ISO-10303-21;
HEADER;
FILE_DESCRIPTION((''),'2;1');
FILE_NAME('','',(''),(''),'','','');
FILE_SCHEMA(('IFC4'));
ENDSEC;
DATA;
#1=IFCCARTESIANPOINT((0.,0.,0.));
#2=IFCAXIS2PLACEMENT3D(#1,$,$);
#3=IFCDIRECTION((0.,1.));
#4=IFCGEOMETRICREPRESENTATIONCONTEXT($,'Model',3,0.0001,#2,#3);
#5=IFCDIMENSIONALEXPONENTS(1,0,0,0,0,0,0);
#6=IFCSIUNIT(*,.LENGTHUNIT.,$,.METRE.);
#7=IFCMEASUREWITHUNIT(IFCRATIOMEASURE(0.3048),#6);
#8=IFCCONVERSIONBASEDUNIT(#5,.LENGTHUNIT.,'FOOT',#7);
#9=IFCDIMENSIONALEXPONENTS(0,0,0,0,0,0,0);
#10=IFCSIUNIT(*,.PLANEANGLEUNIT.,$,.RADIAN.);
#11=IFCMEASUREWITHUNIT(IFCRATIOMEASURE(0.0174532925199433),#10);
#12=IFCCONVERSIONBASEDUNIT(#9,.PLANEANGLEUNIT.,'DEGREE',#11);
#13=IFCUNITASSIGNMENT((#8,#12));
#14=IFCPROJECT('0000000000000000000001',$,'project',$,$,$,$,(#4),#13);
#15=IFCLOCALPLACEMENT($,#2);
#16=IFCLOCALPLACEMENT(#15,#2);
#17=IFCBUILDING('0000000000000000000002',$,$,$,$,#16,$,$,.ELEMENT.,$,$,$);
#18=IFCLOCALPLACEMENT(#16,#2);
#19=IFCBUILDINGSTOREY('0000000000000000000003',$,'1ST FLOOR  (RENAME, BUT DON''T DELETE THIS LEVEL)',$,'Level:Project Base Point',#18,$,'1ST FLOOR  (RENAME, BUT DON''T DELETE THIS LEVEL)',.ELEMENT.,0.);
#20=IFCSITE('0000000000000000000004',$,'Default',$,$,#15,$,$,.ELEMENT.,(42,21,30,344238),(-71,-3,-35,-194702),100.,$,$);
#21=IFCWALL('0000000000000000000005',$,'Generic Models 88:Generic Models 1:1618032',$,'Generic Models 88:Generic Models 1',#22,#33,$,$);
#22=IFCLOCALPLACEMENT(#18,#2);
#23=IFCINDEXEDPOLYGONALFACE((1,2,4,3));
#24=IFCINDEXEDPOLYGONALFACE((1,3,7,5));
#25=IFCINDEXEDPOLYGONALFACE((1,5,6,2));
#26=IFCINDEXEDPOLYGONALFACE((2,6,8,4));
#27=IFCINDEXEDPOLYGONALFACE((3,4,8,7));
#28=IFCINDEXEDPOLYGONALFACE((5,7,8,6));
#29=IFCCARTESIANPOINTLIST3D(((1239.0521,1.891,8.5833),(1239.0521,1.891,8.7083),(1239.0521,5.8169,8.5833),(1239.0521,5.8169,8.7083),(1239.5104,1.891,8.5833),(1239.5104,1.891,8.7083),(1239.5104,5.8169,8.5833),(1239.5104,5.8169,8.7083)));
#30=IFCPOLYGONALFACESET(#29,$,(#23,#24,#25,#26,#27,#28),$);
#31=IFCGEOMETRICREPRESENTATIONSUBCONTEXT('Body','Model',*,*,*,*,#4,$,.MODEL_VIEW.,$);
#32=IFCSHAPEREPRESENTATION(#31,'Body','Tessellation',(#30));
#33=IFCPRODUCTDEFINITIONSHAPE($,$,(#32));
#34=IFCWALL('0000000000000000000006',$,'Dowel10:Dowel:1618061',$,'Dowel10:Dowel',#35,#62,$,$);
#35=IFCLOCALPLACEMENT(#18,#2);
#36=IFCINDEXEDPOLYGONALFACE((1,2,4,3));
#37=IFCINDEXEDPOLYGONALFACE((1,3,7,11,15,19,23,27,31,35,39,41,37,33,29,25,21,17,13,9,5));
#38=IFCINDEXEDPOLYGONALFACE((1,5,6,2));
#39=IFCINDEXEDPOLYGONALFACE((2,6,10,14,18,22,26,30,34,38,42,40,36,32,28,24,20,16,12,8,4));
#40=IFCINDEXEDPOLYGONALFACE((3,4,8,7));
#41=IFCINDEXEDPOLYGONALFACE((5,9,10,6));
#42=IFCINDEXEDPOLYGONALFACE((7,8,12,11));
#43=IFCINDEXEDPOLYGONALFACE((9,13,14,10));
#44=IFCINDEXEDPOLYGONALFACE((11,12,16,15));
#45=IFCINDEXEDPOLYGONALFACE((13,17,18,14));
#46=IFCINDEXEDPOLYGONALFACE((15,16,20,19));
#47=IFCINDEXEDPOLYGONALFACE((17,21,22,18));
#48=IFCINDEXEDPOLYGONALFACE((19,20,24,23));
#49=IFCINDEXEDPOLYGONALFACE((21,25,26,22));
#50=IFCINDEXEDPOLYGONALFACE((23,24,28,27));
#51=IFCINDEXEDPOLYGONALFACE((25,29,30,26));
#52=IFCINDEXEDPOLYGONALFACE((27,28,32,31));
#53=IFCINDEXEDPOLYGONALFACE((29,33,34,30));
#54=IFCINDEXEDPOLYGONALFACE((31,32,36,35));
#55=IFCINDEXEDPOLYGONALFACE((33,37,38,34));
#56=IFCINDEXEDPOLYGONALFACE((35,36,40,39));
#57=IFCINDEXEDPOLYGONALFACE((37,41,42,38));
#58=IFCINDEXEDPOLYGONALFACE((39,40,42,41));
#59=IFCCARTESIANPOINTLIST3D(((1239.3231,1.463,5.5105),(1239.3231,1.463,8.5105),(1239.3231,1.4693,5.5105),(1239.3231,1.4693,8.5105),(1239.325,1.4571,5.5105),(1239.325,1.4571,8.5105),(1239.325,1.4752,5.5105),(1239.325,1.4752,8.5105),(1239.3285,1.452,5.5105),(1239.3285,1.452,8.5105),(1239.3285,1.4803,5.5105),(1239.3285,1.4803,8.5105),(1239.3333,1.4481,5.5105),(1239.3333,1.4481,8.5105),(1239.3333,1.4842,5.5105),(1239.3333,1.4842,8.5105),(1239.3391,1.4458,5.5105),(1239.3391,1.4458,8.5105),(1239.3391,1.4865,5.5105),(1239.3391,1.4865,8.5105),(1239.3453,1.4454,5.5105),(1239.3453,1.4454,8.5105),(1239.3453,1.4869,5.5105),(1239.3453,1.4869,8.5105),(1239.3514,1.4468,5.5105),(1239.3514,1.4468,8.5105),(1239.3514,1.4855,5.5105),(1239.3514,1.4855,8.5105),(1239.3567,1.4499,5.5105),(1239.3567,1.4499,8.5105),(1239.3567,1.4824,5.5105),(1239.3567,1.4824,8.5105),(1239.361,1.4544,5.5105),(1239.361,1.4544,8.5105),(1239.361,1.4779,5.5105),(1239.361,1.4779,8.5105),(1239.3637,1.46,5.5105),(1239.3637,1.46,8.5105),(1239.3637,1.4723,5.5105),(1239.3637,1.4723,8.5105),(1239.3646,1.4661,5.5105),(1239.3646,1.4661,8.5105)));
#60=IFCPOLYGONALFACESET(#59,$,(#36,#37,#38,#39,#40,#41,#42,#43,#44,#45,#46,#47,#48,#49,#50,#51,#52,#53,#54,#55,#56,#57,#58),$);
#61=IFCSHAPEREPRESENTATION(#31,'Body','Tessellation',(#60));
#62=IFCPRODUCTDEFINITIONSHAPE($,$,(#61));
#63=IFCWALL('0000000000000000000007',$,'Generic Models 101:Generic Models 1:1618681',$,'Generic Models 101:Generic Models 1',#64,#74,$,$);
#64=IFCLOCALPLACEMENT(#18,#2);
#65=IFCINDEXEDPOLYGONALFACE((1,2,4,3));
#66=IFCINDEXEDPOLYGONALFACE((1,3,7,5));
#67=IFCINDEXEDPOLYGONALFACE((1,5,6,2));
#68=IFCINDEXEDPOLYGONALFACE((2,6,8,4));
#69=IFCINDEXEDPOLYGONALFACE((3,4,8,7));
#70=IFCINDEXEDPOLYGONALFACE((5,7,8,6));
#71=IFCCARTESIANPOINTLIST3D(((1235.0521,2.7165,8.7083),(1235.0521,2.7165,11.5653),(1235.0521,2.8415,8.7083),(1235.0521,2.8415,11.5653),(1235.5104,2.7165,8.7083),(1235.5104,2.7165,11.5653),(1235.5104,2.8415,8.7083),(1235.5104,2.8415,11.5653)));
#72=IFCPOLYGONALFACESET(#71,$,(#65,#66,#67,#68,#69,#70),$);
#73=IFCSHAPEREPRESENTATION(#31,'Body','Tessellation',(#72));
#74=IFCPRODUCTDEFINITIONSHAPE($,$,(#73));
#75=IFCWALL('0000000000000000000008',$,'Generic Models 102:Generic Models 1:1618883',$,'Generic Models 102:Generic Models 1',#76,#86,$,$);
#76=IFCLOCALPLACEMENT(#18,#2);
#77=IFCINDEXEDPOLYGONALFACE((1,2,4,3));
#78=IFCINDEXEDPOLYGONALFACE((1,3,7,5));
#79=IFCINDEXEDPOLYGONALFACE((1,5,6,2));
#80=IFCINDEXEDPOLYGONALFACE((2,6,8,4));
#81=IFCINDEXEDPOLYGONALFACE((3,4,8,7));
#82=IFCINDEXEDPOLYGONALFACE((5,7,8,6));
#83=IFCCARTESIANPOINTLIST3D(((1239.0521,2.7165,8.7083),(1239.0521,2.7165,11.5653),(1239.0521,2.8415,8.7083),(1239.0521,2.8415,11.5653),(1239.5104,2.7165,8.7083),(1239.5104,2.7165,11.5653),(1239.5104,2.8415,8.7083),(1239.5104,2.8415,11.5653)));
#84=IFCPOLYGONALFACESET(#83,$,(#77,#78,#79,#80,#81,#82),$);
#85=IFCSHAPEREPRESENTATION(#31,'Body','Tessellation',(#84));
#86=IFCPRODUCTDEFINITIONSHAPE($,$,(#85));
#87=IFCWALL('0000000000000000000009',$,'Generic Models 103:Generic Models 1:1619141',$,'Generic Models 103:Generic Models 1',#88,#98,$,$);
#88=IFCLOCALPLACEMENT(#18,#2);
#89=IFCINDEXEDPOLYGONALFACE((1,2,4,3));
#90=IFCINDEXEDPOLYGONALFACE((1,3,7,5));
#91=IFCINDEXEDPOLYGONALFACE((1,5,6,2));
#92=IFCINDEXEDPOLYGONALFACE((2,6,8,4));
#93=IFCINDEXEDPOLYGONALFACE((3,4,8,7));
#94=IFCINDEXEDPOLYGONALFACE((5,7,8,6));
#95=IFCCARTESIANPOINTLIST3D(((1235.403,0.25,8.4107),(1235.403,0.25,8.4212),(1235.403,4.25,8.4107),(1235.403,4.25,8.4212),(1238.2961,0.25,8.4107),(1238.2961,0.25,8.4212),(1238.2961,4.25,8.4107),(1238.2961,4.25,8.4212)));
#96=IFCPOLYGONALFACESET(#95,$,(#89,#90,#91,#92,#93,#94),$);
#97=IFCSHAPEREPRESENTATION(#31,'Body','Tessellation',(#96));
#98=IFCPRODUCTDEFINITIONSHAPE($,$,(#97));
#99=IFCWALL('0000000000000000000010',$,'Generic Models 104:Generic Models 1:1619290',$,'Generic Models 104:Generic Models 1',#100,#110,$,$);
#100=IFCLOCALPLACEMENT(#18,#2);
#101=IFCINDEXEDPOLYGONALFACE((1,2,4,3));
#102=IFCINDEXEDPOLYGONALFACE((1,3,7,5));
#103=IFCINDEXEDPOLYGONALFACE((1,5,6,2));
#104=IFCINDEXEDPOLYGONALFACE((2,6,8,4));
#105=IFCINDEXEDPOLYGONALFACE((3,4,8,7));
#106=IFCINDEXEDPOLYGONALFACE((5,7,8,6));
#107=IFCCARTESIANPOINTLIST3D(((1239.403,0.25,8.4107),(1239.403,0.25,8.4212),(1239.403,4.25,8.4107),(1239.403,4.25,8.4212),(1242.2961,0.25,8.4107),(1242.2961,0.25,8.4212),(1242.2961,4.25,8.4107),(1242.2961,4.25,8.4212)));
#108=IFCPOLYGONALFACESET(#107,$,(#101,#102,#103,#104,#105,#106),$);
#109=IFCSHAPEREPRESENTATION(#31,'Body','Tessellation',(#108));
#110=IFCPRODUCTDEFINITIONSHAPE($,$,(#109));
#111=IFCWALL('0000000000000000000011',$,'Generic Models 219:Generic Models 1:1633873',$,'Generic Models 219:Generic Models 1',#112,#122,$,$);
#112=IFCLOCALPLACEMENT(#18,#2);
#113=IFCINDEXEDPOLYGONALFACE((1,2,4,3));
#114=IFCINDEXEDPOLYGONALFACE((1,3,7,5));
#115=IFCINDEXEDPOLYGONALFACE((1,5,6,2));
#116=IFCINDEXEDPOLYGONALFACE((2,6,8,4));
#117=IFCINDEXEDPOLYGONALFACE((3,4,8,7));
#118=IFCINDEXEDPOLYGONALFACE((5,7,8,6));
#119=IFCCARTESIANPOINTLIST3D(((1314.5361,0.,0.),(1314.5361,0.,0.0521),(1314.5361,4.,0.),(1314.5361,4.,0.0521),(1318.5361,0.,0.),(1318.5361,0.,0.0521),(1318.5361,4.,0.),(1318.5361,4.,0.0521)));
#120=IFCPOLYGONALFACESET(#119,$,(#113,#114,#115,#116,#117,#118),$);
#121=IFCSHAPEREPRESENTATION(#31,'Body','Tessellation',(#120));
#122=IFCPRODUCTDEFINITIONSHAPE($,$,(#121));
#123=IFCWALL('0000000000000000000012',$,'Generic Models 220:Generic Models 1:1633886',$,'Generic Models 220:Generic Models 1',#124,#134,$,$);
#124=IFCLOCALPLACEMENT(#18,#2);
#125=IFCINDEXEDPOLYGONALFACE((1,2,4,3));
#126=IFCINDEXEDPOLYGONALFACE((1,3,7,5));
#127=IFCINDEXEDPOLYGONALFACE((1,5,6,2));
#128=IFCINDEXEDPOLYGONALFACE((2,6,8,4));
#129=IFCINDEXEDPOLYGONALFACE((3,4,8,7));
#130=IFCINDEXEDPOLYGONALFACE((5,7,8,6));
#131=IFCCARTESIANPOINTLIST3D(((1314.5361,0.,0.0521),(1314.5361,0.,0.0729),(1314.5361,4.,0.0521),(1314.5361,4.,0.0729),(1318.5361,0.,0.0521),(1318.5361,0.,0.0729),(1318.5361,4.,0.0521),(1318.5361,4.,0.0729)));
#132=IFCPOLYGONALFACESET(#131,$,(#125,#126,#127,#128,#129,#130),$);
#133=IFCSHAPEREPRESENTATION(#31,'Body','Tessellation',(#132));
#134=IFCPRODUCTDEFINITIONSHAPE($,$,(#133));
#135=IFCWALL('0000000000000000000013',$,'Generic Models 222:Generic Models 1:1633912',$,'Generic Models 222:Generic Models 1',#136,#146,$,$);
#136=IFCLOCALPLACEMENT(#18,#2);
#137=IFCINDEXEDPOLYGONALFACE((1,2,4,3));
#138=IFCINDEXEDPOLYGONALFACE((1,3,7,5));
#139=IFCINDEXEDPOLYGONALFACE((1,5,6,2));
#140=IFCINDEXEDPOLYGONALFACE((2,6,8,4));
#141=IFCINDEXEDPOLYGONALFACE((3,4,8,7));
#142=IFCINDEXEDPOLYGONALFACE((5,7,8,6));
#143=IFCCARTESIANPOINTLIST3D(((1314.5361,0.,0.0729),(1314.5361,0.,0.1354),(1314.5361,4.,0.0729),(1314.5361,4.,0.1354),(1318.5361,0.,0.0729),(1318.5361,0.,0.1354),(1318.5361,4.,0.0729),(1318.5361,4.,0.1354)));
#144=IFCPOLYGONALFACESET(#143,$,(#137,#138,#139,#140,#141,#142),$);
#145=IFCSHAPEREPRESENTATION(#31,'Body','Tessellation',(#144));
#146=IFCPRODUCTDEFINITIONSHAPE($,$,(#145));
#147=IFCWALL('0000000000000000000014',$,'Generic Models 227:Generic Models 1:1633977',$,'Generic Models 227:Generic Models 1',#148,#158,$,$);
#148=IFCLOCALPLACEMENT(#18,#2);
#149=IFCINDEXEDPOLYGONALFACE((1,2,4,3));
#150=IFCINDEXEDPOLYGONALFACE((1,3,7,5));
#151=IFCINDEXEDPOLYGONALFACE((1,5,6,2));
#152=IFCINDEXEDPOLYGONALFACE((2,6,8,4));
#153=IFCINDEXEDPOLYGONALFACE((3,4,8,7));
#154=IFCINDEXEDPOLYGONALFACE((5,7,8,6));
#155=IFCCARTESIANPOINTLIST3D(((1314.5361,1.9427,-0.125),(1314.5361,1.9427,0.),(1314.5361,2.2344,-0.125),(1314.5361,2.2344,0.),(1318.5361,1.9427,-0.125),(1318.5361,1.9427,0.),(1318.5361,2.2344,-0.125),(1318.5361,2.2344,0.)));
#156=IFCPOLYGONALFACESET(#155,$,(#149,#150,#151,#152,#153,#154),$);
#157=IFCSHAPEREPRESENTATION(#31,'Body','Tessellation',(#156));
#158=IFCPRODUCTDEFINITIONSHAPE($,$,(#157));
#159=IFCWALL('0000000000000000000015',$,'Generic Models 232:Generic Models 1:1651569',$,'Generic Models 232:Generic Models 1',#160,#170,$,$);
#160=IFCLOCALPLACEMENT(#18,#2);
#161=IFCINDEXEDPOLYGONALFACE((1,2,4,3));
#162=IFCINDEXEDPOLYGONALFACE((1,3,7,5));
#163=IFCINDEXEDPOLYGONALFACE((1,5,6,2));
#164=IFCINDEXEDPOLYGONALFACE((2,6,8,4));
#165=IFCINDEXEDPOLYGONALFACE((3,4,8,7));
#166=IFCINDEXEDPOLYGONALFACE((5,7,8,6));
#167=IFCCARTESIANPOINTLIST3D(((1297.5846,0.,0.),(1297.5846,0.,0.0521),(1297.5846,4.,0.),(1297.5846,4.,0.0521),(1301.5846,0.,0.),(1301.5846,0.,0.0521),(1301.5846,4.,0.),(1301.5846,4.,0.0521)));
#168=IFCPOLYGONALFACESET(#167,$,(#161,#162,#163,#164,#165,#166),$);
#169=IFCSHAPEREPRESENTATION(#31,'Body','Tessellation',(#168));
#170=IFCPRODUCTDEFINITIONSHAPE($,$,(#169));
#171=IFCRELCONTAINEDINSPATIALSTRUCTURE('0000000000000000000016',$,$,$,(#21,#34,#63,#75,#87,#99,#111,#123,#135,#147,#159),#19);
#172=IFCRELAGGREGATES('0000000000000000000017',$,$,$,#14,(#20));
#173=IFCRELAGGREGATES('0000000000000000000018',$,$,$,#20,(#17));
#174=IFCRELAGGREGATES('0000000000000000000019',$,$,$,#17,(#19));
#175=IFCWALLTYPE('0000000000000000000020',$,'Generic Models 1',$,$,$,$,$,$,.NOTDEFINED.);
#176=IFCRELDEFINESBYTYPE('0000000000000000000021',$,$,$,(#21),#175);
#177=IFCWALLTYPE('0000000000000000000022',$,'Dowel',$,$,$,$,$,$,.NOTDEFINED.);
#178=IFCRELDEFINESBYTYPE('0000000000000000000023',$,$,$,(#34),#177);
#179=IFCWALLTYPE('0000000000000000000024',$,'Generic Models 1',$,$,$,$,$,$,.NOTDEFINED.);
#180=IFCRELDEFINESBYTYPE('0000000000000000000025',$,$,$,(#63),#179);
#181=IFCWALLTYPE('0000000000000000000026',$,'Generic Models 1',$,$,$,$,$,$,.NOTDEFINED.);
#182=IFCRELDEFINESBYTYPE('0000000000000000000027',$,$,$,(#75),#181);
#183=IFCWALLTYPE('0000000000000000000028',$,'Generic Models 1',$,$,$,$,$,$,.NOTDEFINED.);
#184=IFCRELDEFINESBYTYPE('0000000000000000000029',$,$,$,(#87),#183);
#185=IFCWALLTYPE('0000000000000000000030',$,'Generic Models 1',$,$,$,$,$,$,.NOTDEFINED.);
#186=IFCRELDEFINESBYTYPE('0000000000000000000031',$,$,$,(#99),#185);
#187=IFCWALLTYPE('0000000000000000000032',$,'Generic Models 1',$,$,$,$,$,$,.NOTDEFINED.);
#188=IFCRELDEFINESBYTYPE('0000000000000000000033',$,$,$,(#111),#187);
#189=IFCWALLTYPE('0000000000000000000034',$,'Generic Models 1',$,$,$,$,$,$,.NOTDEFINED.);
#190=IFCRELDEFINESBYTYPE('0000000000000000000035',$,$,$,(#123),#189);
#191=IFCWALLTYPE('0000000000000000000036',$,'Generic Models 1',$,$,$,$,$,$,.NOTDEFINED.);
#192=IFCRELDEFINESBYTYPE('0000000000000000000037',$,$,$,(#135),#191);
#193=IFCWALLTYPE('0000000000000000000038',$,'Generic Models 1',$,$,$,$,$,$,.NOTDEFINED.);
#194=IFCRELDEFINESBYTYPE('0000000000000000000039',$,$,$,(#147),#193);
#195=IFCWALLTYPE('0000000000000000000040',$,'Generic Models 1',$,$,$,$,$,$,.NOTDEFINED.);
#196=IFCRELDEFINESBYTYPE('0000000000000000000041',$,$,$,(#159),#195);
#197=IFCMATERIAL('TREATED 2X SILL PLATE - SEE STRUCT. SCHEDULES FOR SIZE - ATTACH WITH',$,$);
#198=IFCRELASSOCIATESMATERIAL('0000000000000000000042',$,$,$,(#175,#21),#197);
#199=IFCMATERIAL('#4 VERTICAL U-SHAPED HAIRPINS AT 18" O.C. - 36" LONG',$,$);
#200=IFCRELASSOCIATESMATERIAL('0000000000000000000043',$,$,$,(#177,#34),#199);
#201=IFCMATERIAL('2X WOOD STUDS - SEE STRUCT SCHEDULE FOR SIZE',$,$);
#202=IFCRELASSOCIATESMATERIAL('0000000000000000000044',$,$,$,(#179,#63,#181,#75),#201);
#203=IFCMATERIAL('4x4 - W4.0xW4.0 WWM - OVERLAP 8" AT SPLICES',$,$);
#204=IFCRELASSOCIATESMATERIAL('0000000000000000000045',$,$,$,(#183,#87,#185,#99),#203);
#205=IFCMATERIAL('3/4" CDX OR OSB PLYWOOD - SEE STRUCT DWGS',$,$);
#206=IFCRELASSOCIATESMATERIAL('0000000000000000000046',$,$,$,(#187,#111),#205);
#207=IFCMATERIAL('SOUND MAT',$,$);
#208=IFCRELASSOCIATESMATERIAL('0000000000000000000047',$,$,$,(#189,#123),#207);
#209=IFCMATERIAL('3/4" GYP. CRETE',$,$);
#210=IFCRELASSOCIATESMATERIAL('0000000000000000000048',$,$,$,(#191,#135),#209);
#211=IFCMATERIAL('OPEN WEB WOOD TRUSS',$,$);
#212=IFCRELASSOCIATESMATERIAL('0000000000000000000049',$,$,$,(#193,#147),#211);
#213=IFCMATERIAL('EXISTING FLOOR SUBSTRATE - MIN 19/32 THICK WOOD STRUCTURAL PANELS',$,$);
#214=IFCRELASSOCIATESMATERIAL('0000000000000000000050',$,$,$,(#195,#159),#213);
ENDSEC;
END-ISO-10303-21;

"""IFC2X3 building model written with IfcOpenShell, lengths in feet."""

from ifc_helpers import new_model, entity, si_unit, converted_unit, direction, frame, frame_2d, origin, origin_2d_with_axis, place, context, subcontext, project, spatial, rectangle, circle, extrude, material, type_object, element, save


model = new_model("IFC2X3")

# Units and contexts
model_context = context("Model", 3, precision=0.0001, world=origin(), true_north=direction((0.0, 1.0)))
body_context = subcontext(model_context, "Body", "Model", "MODEL_VIEW")
ifc_project = project(units=[converted_unit("LENGTHUNIT", "FOOT", entity("IfcRatioMeasure", 0.3048), si_unit("LENGTHUNIT", "METRE"), dimensions=[1, 0, 0, 0, 0, 0, 0]), converted_unit("PLANEANGLEUNIT", "DEGREE", entity("IfcRatioMeasure", 0.0174532925199433), si_unit("PLANEANGLEUNIT", "RADIAN"), dimensions=[0, 0, 0, 0, 0, 0, 0])], contexts=[model_context])

# Site, building, storey
site_placement = place(None, origin())
site = spatial("IfcSite", under=ifc_project, at=site_placement, Name="Default", CompositionType="ELEMENT", RefLatitude=(42, 21, 30, 344238), RefLongitude=(-71, -3, -35, -194702), RefElevation=100.0)
building_placement = place(site_placement, origin())
building = spatial("IfcBuilding", under=site, at=building_placement, CompositionType="ELEMENT")
storey_placement = place(building_placement, origin())
storey = spatial("IfcBuildingStorey", under=building, at=storey_placement, Name="1ST FLOOR  (RENAME, BUT DON'T DELETE THIS LEVEL)", ObjectType="Level:Project Base Point", LongName="1ST FLOOR  (RENAME, BUT DON'T DELETE THIS LEVEL)", CompositionType="ELEMENT", Elevation=0.0)

# Walls
ifc_material_1 = material(Name="3/4\" CDX OR OSB PLYWOOD - SEE STRUCT DWGS")
ifc_material_2 = material(Name="SOUND MAT")
ifc_material_3 = material(Name="3/4\" GYP. CRETE")
ifc_material_4 = material(Name="OPEN WEB WOOD TRUSS")
ifc_material_5 = material(Name="#4 VERTICAL U-SHAPED HAIRPINS AT 18\" O.C. - 36\" LONG")
ifc_material_6 = material(Name="TREATED 2X SILL PLATE - SEE STRUCT. SCHEDULES FOR SIZE - ATTACH WITH")
wall_type_1 = type_object("IfcWallType", Name="Generic Models 1", PredefinedType="NOTDEFINED", material=ifc_material_6)
wall_1_placement = place(storey_placement, frame((1239.0521, 1.891, 8.5833), z_axis=(0.0, 0.0, 1.0), x_axis=(0.0, 1.0, 0.0)))
element("IfcWall", 1, at=wall_1_placement, inside=storey, type_object=wall_type_1, material=ifc_material_6, Name="Generic Models 88:Generic Models 1:1618032", ObjectType="Generic Models 88:Generic Models 1", context=body_context, shape_type="SweptSolid", body=[
    extrude(rectangle(XDim=3.9258, YDim=0.4583, at=frame_2d((0.0, 0.0), x_axis=(1.0, 0.0))), frame((1.9629, -0.2292, 0.0)), (0.0, 0.0, 1.0), 0.125),
])
wall_type_2 = type_object("IfcWallType", Name="Dowel", PredefinedType="NOTDEFINED", material=ifc_material_5)
wall_2_placement = place(storey_placement, frame((1239.3229, 1.4453, 5.5105)))
element("IfcWall", 2, at=wall_2_placement, inside=storey, type_object=wall_type_2, material=ifc_material_5, Name="Dowel10:Dowel:1618061", ObjectType="Dowel10:Dowel", context=body_context, shape_type="SweptSolid", body=[
    extrude(circle(Radius=0.0208, at=frame_2d((0.0, 0.0), x_axis=(1.0, 0.0))), frame((0.0208, 0.0208, 0.0)), (0.0, 0.0, 1.0), 3.0),
])
ifc_material_7 = material(Name="2X WOOD STUDS - SEE STRUCT SCHEDULE FOR SIZE")
wall_type_3 = type_object("IfcWallType", Name="Generic Models 1", PredefinedType="NOTDEFINED", material=ifc_material_7)
wall_3_placement = place(storey_placement, frame((1235.0521, 2.7165, 8.7083)))
element("IfcWall", 3, at=wall_3_placement, inside=storey, type_object=wall_type_3, material=ifc_material_7, Name="Generic Models 101:Generic Models 1:1618681", ObjectType="Generic Models 101:Generic Models 1", context=body_context, shape_type="SweptSolid", body=[
    extrude(rectangle(XDim=0.125, YDim=0.4583, at=frame_2d((0.0, 0.0), x_axis=(1.0, 0.0))), frame((0.2292, 0.0625, 0.0), z_axis=(0.0, 0.0, 1.0), x_axis=(0.0, 1.0, 0.0)), (0.0, 0.0, 1.0), 2.857),
])
wall_type_4 = type_object("IfcWallType", Name="Generic Models 1", PredefinedType="NOTDEFINED", material=ifc_material_7)
wall_4_placement = place(storey_placement, frame((1239.0521, 2.7165, 8.7083)))
element("IfcWall", 4, at=wall_4_placement, inside=storey, type_object=wall_type_4, material=ifc_material_7, Name="Generic Models 102:Generic Models 1:1618883", ObjectType="Generic Models 102:Generic Models 1", context=body_context, shape_type="SweptSolid", body=[
    extrude(rectangle(XDim=0.125, YDim=0.4583, at=frame_2d((0.0, 0.0), x_axis=(1.0, 0.0))), frame((0.2292, 0.0625, 0.0), z_axis=(0.0, 0.0, 1.0), x_axis=(0.0, 1.0, 0.0)), (0.0, 0.0, 1.0), 2.857),
])
ifc_material_8 = material(Name="4x4 - W4.0xW4.0 WWM - OVERLAP 8\" AT SPLICES")
wall_type_5 = type_object("IfcWallType", Name="Generic Models 1", PredefinedType="NOTDEFINED", material=ifc_material_8)
wall_5_placement = place(storey_placement, frame((1235.403, 0.25, 8.4107), z_axis=(0.0, 0.0, 1.0), x_axis=(0.0, 1.0, 0.0)))
element("IfcWall", 5, at=wall_5_placement, inside=storey, type_object=wall_type_5, material=ifc_material_8, Name="Generic Models 103:Generic Models 1:1619141", ObjectType="Generic Models 103:Generic Models 1", context=body_context, shape_type="SweptSolid", body=[
    extrude(rectangle(XDim=4.0, YDim=2.8931, at=frame_2d((0.0, 0.0), x_axis=(1.0, 0.0))), frame((2.0, -1.4465, 0.0)), (0.0, 0.0, 1.0), 0.0104),
])
wall_type_6 = type_object("IfcWallType", Name="Generic Models 1", PredefinedType="NOTDEFINED", material=ifc_material_8)
wall_6_placement = place(storey_placement, frame((1239.403, 0.25, 8.4107), z_axis=(0.0, 0.0, 1.0), x_axis=(0.0, 1.0, 0.0)))
element("IfcWall", 6, at=wall_6_placement, inside=storey, type_object=wall_type_6, material=ifc_material_8, Name="Generic Models 104:Generic Models 1:1619290", ObjectType="Generic Models 104:Generic Models 1", context=body_context, shape_type="SweptSolid", body=[
    extrude(rectangle(XDim=4.0, YDim=2.8931, at=frame_2d((0.0, 0.0), x_axis=(1.0, 0.0))), frame((2.0, -1.4465, 0.0)), (0.0, 0.0, 1.0), 0.0104),
])
wall_type_7 = type_object("IfcWallType", Name="Generic Models 1", PredefinedType="NOTDEFINED", material=ifc_material_1)
wall_7_placement = place(storey_placement, frame((1314.5361, 0.0, 0.0), z_axis=(0.0, 0.0, 1.0), x_axis=(0.0, 1.0, 0.0)))
element("IfcWall", 7, at=wall_7_placement, inside=storey, type_object=wall_type_7, material=ifc_material_1, Name="Generic Models 219:Generic Models 1:1633873", ObjectType="Generic Models 219:Generic Models 1", context=body_context, shape_type="SweptSolid", body=[
    extrude(rectangle(XDim=4.0, YDim=4.0, at=origin_2d_with_axis()), frame((2.0, -2.0, 0.0)), (0.0, 0.0, 1.0), 0.0521),
])
wall_type_8 = type_object("IfcWallType", Name="Generic Models 1", PredefinedType="NOTDEFINED", material=ifc_material_2)
wall_8_placement = place(storey_placement, frame((1314.5361, 0.0, 0.0521), z_axis=(0.0, 0.0, 1.0), x_axis=(0.0, 1.0, 0.0)))
element("IfcWall", 8, at=wall_8_placement, inside=storey, type_object=wall_type_8, material=ifc_material_2, Name="Generic Models 220:Generic Models 1:1633886", ObjectType="Generic Models 220:Generic Models 1", context=body_context, shape_type="SweptSolid", body=[
    extrude(rectangle(XDim=4.0, YDim=4.0, at=origin_2d_with_axis()), frame((2.0, -2.0, 0.0)), (0.0, 0.0, 1.0), 0.0208),
])
wall_type_9 = type_object("IfcWallType", Name="Generic Models 1", PredefinedType="NOTDEFINED", material=ifc_material_3)
wall_9_placement = place(storey_placement, frame((1314.5361, 0.0, 0.0729), z_axis=(0.0, 0.0, 1.0), x_axis=(0.0, 1.0, 0.0)))
element("IfcWall", 9, at=wall_9_placement, inside=storey, type_object=wall_type_9, material=ifc_material_3, Name="Generic Models 222:Generic Models 1:1633912", ObjectType="Generic Models 222:Generic Models 1", context=body_context, shape_type="SweptSolid", body=[
    extrude(rectangle(XDim=4.0, YDim=4.0, at=origin_2d_with_axis()), frame((2.0, -2.0, 0.0)), (0.0, 0.0, 1.0), 0.0625),
])
wall_type_10 = type_object("IfcWallType", Name="Generic Models 1", PredefinedType="NOTDEFINED", material=ifc_material_4)
wall_10_placement = place(storey_placement, frame((1314.5361, 1.9427, -0.125)))
element("IfcWall", 10, at=wall_10_placement, inside=storey, type_object=wall_type_10, material=ifc_material_4, Name="Generic Models 227:Generic Models 1:1633977", ObjectType="Generic Models 227:Generic Models 1", context=body_context, shape_type="SweptSolid", body=[
    extrude(rectangle(XDim=0.2917, YDim=4.0, at=frame_2d((0.0, 0.0), x_axis=(1.0, 0.0))), frame((2.0, 0.1458, 0.0), z_axis=(0.0, 0.0, 1.0), x_axis=(0.0, 1.0, 0.0)), (0.0, 0.0, 1.0), 0.125),
])
ifc_material_9 = material(Name="EXISTING FLOOR SUBSTRATE - MIN 19/32 THICK WOOD STRUCTURAL PANELS")
wall_type_11 = type_object("IfcWallType", Name="Generic Models 1", PredefinedType="NOTDEFINED", material=ifc_material_9)
wall_11_placement = place(storey_placement, frame((1297.5846, 0.0, 0.0), z_axis=(0.0, 0.0, 1.0), x_axis=(0.0, 1.0, 0.0)))
element("IfcWall", 11, at=wall_11_placement, inside=storey, type_object=wall_type_11, material=ifc_material_9, Name="Generic Models 232:Generic Models 1:1651569", ObjectType="Generic Models 232:Generic Models 1", context=body_context, shape_type="SweptSolid", body=[
    extrude(rectangle(XDim=4.0, YDim=4.0, at=origin_2d_with_axis()), frame((2.0, -2.0, 0.0)), (0.0, 0.0, 1.0), 0.0521),
])

save(model, "model.ifc")
